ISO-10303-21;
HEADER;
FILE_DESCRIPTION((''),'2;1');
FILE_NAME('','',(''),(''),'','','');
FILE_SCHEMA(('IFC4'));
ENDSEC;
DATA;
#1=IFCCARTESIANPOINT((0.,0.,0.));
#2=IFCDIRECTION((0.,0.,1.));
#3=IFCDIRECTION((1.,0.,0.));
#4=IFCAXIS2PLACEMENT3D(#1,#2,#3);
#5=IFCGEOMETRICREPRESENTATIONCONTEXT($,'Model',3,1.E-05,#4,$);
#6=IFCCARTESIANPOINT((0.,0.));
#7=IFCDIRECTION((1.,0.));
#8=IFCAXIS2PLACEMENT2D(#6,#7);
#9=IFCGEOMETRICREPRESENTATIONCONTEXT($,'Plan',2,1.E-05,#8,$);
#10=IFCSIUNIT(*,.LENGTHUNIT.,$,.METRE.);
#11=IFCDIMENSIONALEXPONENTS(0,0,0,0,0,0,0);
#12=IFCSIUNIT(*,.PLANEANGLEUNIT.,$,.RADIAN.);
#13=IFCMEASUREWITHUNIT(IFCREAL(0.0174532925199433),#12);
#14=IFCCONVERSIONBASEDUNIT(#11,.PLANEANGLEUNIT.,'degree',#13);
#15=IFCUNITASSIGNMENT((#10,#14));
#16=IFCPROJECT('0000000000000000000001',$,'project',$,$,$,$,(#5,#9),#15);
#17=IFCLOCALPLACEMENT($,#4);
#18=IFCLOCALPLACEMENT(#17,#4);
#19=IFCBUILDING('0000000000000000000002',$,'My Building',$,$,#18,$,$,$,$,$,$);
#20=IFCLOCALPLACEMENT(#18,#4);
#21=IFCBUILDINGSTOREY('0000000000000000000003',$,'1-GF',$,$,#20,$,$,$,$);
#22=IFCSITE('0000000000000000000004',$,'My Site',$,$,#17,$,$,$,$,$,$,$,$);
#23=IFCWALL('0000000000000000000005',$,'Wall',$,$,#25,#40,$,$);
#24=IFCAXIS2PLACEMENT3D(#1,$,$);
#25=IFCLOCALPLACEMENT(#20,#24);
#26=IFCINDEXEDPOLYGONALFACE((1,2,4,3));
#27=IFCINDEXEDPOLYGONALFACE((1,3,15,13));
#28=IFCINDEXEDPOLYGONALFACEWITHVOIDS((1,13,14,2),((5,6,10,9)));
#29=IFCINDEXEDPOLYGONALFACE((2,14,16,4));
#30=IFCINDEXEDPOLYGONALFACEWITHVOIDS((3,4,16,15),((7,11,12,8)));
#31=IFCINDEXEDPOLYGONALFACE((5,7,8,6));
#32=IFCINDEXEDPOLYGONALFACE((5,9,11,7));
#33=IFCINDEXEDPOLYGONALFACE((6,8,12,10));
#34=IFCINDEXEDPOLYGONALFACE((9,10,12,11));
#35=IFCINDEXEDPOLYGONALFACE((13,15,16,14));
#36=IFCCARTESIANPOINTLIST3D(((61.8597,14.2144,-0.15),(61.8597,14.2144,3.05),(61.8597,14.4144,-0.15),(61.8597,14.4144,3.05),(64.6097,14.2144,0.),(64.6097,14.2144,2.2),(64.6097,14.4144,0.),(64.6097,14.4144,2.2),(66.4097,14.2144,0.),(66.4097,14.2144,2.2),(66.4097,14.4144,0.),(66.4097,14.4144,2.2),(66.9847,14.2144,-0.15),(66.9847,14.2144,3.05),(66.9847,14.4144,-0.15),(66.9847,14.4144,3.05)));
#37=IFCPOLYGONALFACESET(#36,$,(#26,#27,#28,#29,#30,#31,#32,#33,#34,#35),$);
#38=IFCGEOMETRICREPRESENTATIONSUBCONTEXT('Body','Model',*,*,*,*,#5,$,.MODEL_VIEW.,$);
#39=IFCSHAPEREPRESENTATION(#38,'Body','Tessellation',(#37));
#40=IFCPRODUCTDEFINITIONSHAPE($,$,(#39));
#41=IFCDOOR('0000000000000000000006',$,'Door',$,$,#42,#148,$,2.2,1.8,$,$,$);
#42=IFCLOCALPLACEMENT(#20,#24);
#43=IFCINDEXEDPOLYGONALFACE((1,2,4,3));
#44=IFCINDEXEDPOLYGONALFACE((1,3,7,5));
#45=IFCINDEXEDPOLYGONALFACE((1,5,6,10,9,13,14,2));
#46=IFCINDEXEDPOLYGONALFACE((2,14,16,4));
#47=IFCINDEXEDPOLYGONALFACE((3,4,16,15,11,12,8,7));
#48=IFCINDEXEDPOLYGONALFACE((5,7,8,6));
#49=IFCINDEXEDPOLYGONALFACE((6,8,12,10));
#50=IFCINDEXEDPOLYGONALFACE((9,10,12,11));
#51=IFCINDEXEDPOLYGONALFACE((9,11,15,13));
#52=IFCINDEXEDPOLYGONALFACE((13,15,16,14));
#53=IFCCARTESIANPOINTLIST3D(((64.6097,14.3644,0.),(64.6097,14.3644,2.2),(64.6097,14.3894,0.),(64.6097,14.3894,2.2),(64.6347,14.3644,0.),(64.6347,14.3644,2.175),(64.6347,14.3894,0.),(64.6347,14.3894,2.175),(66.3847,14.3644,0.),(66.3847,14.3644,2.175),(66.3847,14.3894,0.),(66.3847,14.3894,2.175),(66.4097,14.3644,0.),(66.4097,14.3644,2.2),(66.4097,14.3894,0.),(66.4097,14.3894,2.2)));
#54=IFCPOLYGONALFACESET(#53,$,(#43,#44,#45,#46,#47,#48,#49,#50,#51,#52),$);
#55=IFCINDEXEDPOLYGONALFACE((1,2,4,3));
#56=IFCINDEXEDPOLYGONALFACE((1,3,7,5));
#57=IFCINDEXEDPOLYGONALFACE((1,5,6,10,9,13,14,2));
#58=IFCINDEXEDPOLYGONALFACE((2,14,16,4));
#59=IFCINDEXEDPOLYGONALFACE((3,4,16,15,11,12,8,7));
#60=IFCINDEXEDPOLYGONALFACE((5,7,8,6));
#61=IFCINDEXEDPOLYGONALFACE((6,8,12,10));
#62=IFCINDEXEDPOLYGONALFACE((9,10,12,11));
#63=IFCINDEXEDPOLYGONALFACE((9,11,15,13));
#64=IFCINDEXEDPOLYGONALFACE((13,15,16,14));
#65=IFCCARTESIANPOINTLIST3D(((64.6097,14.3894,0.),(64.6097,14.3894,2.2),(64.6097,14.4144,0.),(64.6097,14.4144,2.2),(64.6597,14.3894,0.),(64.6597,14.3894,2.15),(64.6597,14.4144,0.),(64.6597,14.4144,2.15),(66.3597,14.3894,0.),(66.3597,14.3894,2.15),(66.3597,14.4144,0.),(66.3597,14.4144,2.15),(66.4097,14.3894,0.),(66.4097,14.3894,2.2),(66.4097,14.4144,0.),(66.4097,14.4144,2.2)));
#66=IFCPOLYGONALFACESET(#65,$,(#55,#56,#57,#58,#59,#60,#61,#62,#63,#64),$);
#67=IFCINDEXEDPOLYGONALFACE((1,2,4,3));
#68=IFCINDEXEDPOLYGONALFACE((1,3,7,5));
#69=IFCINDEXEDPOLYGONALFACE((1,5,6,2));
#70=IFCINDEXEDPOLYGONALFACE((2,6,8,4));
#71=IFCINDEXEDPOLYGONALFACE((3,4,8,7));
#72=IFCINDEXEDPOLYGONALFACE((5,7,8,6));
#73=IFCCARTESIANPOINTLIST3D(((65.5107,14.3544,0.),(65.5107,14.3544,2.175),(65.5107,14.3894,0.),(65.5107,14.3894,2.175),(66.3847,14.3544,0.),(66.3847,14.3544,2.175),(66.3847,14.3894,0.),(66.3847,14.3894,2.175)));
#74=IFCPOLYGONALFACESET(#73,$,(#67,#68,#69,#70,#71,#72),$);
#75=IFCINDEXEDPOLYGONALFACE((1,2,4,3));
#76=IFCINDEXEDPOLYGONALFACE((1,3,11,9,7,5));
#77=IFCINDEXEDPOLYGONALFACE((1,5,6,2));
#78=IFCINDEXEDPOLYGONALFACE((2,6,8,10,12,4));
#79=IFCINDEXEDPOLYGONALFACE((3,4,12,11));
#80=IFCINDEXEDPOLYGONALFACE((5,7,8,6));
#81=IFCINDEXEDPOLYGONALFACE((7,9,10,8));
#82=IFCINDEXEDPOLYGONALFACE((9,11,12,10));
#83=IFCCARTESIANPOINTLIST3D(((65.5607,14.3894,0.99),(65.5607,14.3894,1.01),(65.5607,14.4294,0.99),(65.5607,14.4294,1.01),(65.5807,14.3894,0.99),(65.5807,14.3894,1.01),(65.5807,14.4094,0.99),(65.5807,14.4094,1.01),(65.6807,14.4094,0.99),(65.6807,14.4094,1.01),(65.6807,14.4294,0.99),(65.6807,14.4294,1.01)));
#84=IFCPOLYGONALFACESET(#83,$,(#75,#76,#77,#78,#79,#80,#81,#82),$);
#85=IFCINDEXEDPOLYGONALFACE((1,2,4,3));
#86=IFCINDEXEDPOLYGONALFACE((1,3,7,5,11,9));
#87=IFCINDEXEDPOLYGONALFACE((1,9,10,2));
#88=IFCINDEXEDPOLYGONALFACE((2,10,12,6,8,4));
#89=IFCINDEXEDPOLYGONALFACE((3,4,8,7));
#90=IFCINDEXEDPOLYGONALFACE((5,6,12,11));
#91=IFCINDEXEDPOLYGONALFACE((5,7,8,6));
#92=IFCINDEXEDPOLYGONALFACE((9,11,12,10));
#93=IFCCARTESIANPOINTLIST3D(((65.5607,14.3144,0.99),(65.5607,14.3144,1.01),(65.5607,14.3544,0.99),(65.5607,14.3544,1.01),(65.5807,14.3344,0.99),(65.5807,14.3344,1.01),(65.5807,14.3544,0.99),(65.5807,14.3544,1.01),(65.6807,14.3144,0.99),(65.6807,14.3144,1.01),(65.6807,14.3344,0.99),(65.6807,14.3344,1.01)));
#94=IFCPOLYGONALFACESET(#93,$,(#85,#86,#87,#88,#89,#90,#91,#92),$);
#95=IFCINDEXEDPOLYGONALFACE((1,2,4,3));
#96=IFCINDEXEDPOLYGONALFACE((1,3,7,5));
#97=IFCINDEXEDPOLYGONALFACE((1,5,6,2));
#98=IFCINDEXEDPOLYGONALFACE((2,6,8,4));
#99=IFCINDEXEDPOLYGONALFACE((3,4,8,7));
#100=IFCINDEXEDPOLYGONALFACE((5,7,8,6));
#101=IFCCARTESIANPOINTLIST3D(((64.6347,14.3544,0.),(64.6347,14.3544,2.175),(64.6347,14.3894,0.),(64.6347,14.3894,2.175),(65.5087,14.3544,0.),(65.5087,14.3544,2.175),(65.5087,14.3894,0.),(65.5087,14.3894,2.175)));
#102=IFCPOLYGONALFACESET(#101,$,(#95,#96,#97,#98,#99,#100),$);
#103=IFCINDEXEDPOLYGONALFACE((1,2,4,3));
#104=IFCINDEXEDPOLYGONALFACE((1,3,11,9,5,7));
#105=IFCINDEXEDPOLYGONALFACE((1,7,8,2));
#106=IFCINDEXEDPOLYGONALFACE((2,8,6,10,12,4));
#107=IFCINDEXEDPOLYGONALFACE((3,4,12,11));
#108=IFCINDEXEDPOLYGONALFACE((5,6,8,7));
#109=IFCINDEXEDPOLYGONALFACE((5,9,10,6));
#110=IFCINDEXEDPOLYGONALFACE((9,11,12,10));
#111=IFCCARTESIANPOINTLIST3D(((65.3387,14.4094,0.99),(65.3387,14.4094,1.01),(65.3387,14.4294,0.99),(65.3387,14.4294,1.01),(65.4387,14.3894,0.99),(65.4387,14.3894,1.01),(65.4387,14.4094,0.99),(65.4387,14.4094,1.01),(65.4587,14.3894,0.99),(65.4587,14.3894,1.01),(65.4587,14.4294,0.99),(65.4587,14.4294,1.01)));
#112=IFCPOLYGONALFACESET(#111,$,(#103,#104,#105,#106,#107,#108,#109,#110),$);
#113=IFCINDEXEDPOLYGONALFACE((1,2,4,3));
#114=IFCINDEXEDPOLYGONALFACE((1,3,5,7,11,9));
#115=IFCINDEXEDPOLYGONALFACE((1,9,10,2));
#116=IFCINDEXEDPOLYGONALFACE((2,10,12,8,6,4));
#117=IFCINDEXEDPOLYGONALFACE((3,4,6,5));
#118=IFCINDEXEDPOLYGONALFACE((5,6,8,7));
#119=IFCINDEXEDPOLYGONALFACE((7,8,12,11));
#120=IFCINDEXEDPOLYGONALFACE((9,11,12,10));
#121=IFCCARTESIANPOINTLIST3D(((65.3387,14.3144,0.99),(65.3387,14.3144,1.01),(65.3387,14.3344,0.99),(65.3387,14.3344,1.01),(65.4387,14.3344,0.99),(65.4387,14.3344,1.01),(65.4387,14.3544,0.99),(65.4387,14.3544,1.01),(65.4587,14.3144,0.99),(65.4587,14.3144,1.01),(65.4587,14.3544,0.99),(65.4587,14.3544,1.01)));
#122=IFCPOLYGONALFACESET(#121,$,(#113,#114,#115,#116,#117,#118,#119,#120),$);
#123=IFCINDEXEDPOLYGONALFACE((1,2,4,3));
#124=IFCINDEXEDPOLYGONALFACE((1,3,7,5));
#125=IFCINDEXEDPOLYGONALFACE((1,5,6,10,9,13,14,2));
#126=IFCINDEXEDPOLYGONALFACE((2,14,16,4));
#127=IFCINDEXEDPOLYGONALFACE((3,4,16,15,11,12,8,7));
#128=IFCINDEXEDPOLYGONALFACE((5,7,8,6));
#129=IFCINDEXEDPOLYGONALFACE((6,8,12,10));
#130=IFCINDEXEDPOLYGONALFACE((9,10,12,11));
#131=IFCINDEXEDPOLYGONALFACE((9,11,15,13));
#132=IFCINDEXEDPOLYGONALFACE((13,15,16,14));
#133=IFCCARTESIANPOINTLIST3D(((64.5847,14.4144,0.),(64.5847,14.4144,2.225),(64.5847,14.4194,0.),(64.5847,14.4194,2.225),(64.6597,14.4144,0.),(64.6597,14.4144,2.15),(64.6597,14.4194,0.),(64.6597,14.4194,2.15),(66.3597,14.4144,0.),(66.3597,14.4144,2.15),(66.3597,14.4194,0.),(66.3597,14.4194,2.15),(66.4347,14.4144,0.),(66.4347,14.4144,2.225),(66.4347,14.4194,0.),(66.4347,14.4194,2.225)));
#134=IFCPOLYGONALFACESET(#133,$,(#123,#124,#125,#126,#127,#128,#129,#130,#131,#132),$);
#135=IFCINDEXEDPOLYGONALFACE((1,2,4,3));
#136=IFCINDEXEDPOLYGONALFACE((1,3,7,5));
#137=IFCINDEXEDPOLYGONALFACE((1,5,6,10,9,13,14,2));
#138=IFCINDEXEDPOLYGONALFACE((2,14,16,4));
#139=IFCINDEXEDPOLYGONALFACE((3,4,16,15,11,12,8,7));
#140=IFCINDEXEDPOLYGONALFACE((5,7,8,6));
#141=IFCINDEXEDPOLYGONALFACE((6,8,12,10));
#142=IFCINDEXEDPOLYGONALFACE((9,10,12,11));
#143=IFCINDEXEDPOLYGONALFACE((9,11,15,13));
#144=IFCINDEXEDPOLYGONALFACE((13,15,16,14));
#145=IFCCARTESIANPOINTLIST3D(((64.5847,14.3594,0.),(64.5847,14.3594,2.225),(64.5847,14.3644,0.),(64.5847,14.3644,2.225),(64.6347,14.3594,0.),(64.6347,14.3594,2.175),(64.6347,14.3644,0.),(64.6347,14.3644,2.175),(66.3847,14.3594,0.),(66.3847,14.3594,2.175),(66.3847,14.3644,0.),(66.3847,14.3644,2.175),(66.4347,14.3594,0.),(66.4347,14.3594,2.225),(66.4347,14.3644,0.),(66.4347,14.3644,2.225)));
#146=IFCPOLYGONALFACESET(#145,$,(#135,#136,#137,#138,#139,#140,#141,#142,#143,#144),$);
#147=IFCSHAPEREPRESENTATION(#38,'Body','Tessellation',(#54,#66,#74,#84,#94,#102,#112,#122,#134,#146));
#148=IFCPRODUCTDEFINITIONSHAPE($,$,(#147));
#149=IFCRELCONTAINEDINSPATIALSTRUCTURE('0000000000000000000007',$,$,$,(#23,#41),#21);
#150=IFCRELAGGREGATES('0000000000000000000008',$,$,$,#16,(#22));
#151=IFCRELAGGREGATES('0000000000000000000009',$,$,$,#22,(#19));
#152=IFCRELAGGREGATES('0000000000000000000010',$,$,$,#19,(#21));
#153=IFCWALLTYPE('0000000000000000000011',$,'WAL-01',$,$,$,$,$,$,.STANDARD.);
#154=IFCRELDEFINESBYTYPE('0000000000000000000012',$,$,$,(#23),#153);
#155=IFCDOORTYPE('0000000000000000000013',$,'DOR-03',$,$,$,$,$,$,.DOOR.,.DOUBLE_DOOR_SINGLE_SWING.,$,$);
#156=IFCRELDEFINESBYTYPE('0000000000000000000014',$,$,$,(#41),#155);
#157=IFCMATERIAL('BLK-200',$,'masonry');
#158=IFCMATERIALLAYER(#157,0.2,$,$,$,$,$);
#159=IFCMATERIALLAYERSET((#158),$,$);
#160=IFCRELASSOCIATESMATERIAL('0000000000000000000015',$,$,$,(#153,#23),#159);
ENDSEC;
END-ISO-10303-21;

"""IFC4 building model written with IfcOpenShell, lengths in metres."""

from ifc_helpers import new_model, entity, si_unit, converted_unit, frame, origin_with_axes, origin_2d_with_axis, place, context, subcontext, project, spatial, line, indexed_curve, outline, extrude, shape, source, transform, mapped, material, layer, layer_set, layer_usage, type_object, type_shapes, element, fill, save


model = new_model("IFC4")

# Units and contexts
model_context = context("Model", 3, precision=1e-05, world=origin_with_axes())
plan_context = context("Plan", 2, precision=1e-05, world=origin_2d_with_axis())
body_context_1 = subcontext(model_context, "Body", "Model", "MODEL_VIEW")
body_context_2 = subcontext(plan_context, "Body", "Plan", "PLAN_VIEW")
ifc_project = project(units=[si_unit("LENGTHUNIT", "METRE"), converted_unit("PLANEANGLEUNIT", "degree", entity("IfcReal", 0.0174532925199433), si_unit("PLANEANGLEUNIT", "RADIAN"), dimensions=[0, 0, 0, 0, 0, 0, 0])], contexts=[model_context, plan_context])

# Site, building, storey
site_placement = place(None, origin_with_axes())
site = spatial("IfcSite", under=ifc_project, at=site_placement, Name="My Site")
building_placement = place(site_placement, origin_with_axes())
building = spatial("IfcBuilding", under=site, at=building_placement, Name="My Building")
storey_placement = place(building_placement, origin_with_axes())
storey = spatial("IfcBuildingStorey", under=building, at=storey_placement, Name="1-GF")

# Wall, opening, door
ifc_material_1 = material(Name="BLK-200", Category="masonry")
ifc_layer_1 = layer(ifc_material_1, 0.2)
ifc_layer_set_1 = layer_set([ifc_layer_1])
ifc_layer_usage_1 = layer_usage(ifc_layer_set_1, "AXIS2", "POSITIVE", 0.0)
wall_type_1 = type_object("IfcWallType", Name="WAL-01", PredefinedType="STANDARD", material=ifc_layer_set_1)
wall_1_placement = place(storey_placement, frame((66.9847, 14.4144, -0.15), z_axis=(0.0, 0.0, 1.0), x_axis=(-1.0, 0.0, 0.0)))
wall_1 = element("IfcWall", 1, at=wall_1_placement, inside=storey, type_object=wall_type_1, material=ifc_layer_usage_1, Name="Wall", context=body_context_1, shape_type="SweptSolid", body=[
    extrude(outline(indexed_curve([(0.0, 0.0), (0.0, 0.2), (5.125, 0.2), (5.125, 0.0), (0.0, 0.0)], self_intersect=False)), origin_with_axes(), (0.0, 0.0, 1.0), 3.2),
])
shared_shape_1 = source(origin_with_axes(), body_context_1, "Body", "SweptSolid", [
    extrude(outline(indexed_curve([(0.0, 0.0), (1.8, 0.0), (1.8, 2.2), (0.0, 2.2)], segments=[line(1, 2, 3, 4, 1)])), frame((0.0, -0.1, 0.0), z_axis=(0.0, -1.0, 0.0), x_axis=(1.0, 0.0, 0.0)), (0.0, 0.0, -1.0), 0.4),
])
opening_1_placement = place(wall_1_placement, frame((0.575, 0.0, 0.15), z_axis=(0.0, 0.0, 1.0), x_axis=(1.0, 0.0, 0.0)))
opening_1 = element("IfcOpeningElement", 2, at=opening_1_placement, cuts=wall_1, PredefinedType="OPENING", context=body_context_1, shape_type="MappedRepresentation", body=[
    mapped(shared_shape_1, transform((0.0, 0.0, 0.0), x_axis=(1.0, 0.0, 0.0), y_axis=(0.0, 1.0, 0.0), z_axis=(0.0, 0.0, 1.0), scale=1.0)),
])
door_type_1 = type_object("IfcDoorType", Name="DOR-03", OperationType="DOUBLE_DOOR_SINGLE_SWING", PredefinedType="DOOR")
shared_shape_2 = source(origin_with_axes(), body_context_1, "Body", "SweptSolid", [
    extrude(outline(indexed_curve([(0.0, 0.0), (0.0, 2.2), (1.8, 2.2), (1.8, 0.0), (1.775, 0.0), (1.775, 2.175), (0.025, 2.175), (0.025, 0.0)], segments=[line(1, 2, 3, 4, 5, 6, 7, 8, 1)])), frame((0.0, 0.025, 0.0), z_axis=(0.0, -1.0, 0.0), x_axis=(1.0, 0.0, 0.0)), (0.0, 0.0, -1.0), 0.025),
    extrude(outline(indexed_curve([(0.0, 0.0), (0.0, 2.2), (1.8, 2.2), (1.8, 0.0), (1.75, 0.0), (1.75, 2.15), (0.05, 2.15), (0.05, 0.0)], segments=[line(1, 2, 3, 4, 5, 6, 7, 8, 1)])), frame((0.0, 0.0, 0.0), z_axis=(0.0, -1.0, 0.0), x_axis=(1.0, 0.0, 0.0)), (0.0, 0.0, -1.0), 0.025),
    extrude(outline(indexed_curve([(0.0, 0.0), (0.874, 0.0), (0.874, 0.035), (0.0, 0.035)], segments=[line(1, 2, 3, 4, 1)])), frame((0.025, 0.025, 0.0), z_axis=(0.0, 0.0, 1.0), x_axis=(1.0, 0.0, 0.0)), (0.0, 0.0, 1.0), 2.175),
    extrude(outline(indexed_curve([(0.0, 0.0), (0.0, -0.04), (-0.12, -0.04), (-0.12, -0.02), (-0.02, -0.02), (-0.02, 0.0)], segments=[line(1, 2, 3, 4, 5, 6, 1)])), frame((0.849, 0.025, 0.99), z_axis=(0.0, 0.0, 1.0), x_axis=(1.0, 0.0, 0.0)), (0.0, 0.0, 1.0), 0.02),
    extrude(outline(indexed_curve([(0.0, 0.0), (0.0, 0.04), (-0.12, 0.04), (-0.12, 0.02), (-0.02, 0.02), (-0.02, 0.0)], segments=[line(1, 2, 3, 4, 5, 6, 1)])), frame((0.849, 0.06, 0.99), z_axis=(0.0, 0.0, 1.0), x_axis=(1.0, 0.0, 0.0)), (0.0, 0.0, 1.0), 0.02),
    extrude(outline(indexed_curve([(0.0, 0.0), (-0.874, 0.0), (-0.874, 0.035), (0.0, 0.035)], segments=[line(1, 2, 3, 4, 1)])), frame((1.775, 0.025, 0.0), z_axis=(0.0, 0.0, 1.0), x_axis=(1.0, 0.0, 0.0)), (0.0, 0.0, 1.0), 2.175),
    extrude(outline(indexed_curve([(0.0, 0.0), (0.0, -0.04), (0.12, -0.04), (0.12, -0.02), (0.02, -0.02), (0.02, 0.0)], segments=[line(1, 2, 3, 4, 5, 6, 1)])), frame((0.951, 0.025, 0.99), z_axis=(0.0, 0.0, 1.0), x_axis=(1.0, 0.0, 0.0)), (0.0, 0.0, 1.0), 0.02),
    extrude(outline(indexed_curve([(0.0, 0.0), (0.0, 0.04), (0.12, 0.04), (0.12, 0.02), (0.02, 0.02), (0.02, 0.0)], segments=[line(1, 2, 3, 4, 5, 6, 1)])), frame((0.951, 0.06, 0.99), z_axis=(0.0, 0.0, 1.0), x_axis=(1.0, 0.0, 0.0)), (0.0, 0.0, 1.0), 0.02),
    extrude(outline(indexed_curve([(0.0, 0.0), (0.0, 2.225), (1.85, 2.225), (1.85, 0.0), (1.775, 0.0), (1.775, 2.15), (0.075, 2.15), (0.075, 0.0)], segments=[line(1, 2, 3, 4, 5, 6, 7, 8, 1)])), frame((-0.025, -0.005, 0.0), z_axis=(0.0, -1.0, 0.0), x_axis=(1.0, 0.0, 0.0)), (0.0, 0.0, -1.0), 0.005),
    extrude(outline(indexed_curve([(0.0, 0.0), (0.0, 2.225), (1.85, 2.225), (1.85, 0.0), (1.8, 0.0), (1.8, 2.175), (0.05, 2.175), (0.05, 0.0)], segments=[line(1, 2, 3, 4, 5, 6, 7, 8, 1)])), frame((-0.025, 0.05, 0.0), z_axis=(0.0, -1.0, 0.0), x_axis=(1.0, 0.0, 0.0)), (0.0, 0.0, -1.0), 0.005),
])
shared_shape_3 = source(origin_with_axes(), body_context_2, "Body", "Curve2D", [
    entity("IfcIndexedPolyCurve", entity("IfcCartesianPointList2D", [[0.0, 0.0], [0.0, 0.05], [0.025, 0.05], [0.025, 0.025], [0.05, 0.025], [0.05, 0.0]]), [entity("IfcLineIndex", [1, 2, 3, 4, 5, 6, 1])]),
    entity("IfcIndexedPolyCurve", entity("IfcCartesianPointList2D", [[1.8, 0.0], [1.8, 0.05], [1.775, 0.05], [1.775, 0.025], [1.75, 0.025], [1.75, 0.0]]), [entity("IfcLineIndex", [1, 2, 3, 4, 5, 6, 1])]),
    entity("IfcTrimmedCurve", entity("IfcEllipse", entity("IfcAxis2Placement2D", entity("IfcCartesianPoint", [0.06, 0.05]), entity("IfcDirection", [1.0, 0.0])), 0.84, 0.875), [entity("IfcCartesianPoint", [0.9, 0.05])], [entity("IfcCartesianPoint", [0.06, 0.925])], True, "CARTESIAN"),
    entity("IfcIndexedPolyCurve", entity("IfcCartesianPointList2D", [[0.025, 0.05], [0.06, 0.05], [0.06, 0.925], [0.025, 0.925]]), [entity("IfcLineIndex", [1, 2, 3, 4, 1])]),
    entity("IfcTrimmedCurve", entity("IfcEllipse", entity("IfcAxis2Placement2D", entity("IfcCartesianPoint", [1.74, 0.05]), entity("IfcDirection", [1.0, 0.0])), 0.84, 0.875), [entity("IfcCartesianPoint", [1.74, 0.925])], [entity("IfcCartesianPoint", [0.9, 0.05])], True, "CARTESIAN"),
    entity("IfcIndexedPolyCurve", entity("IfcCartesianPointList2D", [[1.775, 0.05], [1.74, 0.05], [1.74, 0.925], [1.775, 0.925]]), [entity("IfcLineIndex", [1, 2, 3, 4, 1])]),
])
type_shapes(door_type_1, [shared_shape_2, shared_shape_3])
door_1_placement = place(opening_1_placement, frame((0.0, 0.0, 0.0), z_axis=(0.0, 0.0, 1.0), x_axis=(1.0, 0.0, 0.0)))
door_1 = element("IfcDoor", 3, at=door_1_placement, inside=storey, type_object=door_type_1, Name="Door", OverallHeight=2.2, OverallWidth=1.8, shapes=[
    shape(body_context_1, "Body", "MappedRepresentation", [mapped(shared_shape_2, transform((0.0, 0.0, 0.0), x_axis=(1.0, 0.0, 0.0), y_axis=(0.0, 1.0, 0.0), z_axis=(0.0, 0.0, 1.0), scale=1.0))]),
    shape(body_context_2, "Body", "MappedRepresentation", [mapped(shared_shape_3, transform((0.0, 0.0, 0.0), x_axis=(1.0, 0.0, 0.0), y_axis=(0.0, 1.0, 0.0), z_axis=(0.0, 0.0, 1.0), scale=1.0))]),
])
fill(opening_1, door_1)

save(model, "model.ifc")
